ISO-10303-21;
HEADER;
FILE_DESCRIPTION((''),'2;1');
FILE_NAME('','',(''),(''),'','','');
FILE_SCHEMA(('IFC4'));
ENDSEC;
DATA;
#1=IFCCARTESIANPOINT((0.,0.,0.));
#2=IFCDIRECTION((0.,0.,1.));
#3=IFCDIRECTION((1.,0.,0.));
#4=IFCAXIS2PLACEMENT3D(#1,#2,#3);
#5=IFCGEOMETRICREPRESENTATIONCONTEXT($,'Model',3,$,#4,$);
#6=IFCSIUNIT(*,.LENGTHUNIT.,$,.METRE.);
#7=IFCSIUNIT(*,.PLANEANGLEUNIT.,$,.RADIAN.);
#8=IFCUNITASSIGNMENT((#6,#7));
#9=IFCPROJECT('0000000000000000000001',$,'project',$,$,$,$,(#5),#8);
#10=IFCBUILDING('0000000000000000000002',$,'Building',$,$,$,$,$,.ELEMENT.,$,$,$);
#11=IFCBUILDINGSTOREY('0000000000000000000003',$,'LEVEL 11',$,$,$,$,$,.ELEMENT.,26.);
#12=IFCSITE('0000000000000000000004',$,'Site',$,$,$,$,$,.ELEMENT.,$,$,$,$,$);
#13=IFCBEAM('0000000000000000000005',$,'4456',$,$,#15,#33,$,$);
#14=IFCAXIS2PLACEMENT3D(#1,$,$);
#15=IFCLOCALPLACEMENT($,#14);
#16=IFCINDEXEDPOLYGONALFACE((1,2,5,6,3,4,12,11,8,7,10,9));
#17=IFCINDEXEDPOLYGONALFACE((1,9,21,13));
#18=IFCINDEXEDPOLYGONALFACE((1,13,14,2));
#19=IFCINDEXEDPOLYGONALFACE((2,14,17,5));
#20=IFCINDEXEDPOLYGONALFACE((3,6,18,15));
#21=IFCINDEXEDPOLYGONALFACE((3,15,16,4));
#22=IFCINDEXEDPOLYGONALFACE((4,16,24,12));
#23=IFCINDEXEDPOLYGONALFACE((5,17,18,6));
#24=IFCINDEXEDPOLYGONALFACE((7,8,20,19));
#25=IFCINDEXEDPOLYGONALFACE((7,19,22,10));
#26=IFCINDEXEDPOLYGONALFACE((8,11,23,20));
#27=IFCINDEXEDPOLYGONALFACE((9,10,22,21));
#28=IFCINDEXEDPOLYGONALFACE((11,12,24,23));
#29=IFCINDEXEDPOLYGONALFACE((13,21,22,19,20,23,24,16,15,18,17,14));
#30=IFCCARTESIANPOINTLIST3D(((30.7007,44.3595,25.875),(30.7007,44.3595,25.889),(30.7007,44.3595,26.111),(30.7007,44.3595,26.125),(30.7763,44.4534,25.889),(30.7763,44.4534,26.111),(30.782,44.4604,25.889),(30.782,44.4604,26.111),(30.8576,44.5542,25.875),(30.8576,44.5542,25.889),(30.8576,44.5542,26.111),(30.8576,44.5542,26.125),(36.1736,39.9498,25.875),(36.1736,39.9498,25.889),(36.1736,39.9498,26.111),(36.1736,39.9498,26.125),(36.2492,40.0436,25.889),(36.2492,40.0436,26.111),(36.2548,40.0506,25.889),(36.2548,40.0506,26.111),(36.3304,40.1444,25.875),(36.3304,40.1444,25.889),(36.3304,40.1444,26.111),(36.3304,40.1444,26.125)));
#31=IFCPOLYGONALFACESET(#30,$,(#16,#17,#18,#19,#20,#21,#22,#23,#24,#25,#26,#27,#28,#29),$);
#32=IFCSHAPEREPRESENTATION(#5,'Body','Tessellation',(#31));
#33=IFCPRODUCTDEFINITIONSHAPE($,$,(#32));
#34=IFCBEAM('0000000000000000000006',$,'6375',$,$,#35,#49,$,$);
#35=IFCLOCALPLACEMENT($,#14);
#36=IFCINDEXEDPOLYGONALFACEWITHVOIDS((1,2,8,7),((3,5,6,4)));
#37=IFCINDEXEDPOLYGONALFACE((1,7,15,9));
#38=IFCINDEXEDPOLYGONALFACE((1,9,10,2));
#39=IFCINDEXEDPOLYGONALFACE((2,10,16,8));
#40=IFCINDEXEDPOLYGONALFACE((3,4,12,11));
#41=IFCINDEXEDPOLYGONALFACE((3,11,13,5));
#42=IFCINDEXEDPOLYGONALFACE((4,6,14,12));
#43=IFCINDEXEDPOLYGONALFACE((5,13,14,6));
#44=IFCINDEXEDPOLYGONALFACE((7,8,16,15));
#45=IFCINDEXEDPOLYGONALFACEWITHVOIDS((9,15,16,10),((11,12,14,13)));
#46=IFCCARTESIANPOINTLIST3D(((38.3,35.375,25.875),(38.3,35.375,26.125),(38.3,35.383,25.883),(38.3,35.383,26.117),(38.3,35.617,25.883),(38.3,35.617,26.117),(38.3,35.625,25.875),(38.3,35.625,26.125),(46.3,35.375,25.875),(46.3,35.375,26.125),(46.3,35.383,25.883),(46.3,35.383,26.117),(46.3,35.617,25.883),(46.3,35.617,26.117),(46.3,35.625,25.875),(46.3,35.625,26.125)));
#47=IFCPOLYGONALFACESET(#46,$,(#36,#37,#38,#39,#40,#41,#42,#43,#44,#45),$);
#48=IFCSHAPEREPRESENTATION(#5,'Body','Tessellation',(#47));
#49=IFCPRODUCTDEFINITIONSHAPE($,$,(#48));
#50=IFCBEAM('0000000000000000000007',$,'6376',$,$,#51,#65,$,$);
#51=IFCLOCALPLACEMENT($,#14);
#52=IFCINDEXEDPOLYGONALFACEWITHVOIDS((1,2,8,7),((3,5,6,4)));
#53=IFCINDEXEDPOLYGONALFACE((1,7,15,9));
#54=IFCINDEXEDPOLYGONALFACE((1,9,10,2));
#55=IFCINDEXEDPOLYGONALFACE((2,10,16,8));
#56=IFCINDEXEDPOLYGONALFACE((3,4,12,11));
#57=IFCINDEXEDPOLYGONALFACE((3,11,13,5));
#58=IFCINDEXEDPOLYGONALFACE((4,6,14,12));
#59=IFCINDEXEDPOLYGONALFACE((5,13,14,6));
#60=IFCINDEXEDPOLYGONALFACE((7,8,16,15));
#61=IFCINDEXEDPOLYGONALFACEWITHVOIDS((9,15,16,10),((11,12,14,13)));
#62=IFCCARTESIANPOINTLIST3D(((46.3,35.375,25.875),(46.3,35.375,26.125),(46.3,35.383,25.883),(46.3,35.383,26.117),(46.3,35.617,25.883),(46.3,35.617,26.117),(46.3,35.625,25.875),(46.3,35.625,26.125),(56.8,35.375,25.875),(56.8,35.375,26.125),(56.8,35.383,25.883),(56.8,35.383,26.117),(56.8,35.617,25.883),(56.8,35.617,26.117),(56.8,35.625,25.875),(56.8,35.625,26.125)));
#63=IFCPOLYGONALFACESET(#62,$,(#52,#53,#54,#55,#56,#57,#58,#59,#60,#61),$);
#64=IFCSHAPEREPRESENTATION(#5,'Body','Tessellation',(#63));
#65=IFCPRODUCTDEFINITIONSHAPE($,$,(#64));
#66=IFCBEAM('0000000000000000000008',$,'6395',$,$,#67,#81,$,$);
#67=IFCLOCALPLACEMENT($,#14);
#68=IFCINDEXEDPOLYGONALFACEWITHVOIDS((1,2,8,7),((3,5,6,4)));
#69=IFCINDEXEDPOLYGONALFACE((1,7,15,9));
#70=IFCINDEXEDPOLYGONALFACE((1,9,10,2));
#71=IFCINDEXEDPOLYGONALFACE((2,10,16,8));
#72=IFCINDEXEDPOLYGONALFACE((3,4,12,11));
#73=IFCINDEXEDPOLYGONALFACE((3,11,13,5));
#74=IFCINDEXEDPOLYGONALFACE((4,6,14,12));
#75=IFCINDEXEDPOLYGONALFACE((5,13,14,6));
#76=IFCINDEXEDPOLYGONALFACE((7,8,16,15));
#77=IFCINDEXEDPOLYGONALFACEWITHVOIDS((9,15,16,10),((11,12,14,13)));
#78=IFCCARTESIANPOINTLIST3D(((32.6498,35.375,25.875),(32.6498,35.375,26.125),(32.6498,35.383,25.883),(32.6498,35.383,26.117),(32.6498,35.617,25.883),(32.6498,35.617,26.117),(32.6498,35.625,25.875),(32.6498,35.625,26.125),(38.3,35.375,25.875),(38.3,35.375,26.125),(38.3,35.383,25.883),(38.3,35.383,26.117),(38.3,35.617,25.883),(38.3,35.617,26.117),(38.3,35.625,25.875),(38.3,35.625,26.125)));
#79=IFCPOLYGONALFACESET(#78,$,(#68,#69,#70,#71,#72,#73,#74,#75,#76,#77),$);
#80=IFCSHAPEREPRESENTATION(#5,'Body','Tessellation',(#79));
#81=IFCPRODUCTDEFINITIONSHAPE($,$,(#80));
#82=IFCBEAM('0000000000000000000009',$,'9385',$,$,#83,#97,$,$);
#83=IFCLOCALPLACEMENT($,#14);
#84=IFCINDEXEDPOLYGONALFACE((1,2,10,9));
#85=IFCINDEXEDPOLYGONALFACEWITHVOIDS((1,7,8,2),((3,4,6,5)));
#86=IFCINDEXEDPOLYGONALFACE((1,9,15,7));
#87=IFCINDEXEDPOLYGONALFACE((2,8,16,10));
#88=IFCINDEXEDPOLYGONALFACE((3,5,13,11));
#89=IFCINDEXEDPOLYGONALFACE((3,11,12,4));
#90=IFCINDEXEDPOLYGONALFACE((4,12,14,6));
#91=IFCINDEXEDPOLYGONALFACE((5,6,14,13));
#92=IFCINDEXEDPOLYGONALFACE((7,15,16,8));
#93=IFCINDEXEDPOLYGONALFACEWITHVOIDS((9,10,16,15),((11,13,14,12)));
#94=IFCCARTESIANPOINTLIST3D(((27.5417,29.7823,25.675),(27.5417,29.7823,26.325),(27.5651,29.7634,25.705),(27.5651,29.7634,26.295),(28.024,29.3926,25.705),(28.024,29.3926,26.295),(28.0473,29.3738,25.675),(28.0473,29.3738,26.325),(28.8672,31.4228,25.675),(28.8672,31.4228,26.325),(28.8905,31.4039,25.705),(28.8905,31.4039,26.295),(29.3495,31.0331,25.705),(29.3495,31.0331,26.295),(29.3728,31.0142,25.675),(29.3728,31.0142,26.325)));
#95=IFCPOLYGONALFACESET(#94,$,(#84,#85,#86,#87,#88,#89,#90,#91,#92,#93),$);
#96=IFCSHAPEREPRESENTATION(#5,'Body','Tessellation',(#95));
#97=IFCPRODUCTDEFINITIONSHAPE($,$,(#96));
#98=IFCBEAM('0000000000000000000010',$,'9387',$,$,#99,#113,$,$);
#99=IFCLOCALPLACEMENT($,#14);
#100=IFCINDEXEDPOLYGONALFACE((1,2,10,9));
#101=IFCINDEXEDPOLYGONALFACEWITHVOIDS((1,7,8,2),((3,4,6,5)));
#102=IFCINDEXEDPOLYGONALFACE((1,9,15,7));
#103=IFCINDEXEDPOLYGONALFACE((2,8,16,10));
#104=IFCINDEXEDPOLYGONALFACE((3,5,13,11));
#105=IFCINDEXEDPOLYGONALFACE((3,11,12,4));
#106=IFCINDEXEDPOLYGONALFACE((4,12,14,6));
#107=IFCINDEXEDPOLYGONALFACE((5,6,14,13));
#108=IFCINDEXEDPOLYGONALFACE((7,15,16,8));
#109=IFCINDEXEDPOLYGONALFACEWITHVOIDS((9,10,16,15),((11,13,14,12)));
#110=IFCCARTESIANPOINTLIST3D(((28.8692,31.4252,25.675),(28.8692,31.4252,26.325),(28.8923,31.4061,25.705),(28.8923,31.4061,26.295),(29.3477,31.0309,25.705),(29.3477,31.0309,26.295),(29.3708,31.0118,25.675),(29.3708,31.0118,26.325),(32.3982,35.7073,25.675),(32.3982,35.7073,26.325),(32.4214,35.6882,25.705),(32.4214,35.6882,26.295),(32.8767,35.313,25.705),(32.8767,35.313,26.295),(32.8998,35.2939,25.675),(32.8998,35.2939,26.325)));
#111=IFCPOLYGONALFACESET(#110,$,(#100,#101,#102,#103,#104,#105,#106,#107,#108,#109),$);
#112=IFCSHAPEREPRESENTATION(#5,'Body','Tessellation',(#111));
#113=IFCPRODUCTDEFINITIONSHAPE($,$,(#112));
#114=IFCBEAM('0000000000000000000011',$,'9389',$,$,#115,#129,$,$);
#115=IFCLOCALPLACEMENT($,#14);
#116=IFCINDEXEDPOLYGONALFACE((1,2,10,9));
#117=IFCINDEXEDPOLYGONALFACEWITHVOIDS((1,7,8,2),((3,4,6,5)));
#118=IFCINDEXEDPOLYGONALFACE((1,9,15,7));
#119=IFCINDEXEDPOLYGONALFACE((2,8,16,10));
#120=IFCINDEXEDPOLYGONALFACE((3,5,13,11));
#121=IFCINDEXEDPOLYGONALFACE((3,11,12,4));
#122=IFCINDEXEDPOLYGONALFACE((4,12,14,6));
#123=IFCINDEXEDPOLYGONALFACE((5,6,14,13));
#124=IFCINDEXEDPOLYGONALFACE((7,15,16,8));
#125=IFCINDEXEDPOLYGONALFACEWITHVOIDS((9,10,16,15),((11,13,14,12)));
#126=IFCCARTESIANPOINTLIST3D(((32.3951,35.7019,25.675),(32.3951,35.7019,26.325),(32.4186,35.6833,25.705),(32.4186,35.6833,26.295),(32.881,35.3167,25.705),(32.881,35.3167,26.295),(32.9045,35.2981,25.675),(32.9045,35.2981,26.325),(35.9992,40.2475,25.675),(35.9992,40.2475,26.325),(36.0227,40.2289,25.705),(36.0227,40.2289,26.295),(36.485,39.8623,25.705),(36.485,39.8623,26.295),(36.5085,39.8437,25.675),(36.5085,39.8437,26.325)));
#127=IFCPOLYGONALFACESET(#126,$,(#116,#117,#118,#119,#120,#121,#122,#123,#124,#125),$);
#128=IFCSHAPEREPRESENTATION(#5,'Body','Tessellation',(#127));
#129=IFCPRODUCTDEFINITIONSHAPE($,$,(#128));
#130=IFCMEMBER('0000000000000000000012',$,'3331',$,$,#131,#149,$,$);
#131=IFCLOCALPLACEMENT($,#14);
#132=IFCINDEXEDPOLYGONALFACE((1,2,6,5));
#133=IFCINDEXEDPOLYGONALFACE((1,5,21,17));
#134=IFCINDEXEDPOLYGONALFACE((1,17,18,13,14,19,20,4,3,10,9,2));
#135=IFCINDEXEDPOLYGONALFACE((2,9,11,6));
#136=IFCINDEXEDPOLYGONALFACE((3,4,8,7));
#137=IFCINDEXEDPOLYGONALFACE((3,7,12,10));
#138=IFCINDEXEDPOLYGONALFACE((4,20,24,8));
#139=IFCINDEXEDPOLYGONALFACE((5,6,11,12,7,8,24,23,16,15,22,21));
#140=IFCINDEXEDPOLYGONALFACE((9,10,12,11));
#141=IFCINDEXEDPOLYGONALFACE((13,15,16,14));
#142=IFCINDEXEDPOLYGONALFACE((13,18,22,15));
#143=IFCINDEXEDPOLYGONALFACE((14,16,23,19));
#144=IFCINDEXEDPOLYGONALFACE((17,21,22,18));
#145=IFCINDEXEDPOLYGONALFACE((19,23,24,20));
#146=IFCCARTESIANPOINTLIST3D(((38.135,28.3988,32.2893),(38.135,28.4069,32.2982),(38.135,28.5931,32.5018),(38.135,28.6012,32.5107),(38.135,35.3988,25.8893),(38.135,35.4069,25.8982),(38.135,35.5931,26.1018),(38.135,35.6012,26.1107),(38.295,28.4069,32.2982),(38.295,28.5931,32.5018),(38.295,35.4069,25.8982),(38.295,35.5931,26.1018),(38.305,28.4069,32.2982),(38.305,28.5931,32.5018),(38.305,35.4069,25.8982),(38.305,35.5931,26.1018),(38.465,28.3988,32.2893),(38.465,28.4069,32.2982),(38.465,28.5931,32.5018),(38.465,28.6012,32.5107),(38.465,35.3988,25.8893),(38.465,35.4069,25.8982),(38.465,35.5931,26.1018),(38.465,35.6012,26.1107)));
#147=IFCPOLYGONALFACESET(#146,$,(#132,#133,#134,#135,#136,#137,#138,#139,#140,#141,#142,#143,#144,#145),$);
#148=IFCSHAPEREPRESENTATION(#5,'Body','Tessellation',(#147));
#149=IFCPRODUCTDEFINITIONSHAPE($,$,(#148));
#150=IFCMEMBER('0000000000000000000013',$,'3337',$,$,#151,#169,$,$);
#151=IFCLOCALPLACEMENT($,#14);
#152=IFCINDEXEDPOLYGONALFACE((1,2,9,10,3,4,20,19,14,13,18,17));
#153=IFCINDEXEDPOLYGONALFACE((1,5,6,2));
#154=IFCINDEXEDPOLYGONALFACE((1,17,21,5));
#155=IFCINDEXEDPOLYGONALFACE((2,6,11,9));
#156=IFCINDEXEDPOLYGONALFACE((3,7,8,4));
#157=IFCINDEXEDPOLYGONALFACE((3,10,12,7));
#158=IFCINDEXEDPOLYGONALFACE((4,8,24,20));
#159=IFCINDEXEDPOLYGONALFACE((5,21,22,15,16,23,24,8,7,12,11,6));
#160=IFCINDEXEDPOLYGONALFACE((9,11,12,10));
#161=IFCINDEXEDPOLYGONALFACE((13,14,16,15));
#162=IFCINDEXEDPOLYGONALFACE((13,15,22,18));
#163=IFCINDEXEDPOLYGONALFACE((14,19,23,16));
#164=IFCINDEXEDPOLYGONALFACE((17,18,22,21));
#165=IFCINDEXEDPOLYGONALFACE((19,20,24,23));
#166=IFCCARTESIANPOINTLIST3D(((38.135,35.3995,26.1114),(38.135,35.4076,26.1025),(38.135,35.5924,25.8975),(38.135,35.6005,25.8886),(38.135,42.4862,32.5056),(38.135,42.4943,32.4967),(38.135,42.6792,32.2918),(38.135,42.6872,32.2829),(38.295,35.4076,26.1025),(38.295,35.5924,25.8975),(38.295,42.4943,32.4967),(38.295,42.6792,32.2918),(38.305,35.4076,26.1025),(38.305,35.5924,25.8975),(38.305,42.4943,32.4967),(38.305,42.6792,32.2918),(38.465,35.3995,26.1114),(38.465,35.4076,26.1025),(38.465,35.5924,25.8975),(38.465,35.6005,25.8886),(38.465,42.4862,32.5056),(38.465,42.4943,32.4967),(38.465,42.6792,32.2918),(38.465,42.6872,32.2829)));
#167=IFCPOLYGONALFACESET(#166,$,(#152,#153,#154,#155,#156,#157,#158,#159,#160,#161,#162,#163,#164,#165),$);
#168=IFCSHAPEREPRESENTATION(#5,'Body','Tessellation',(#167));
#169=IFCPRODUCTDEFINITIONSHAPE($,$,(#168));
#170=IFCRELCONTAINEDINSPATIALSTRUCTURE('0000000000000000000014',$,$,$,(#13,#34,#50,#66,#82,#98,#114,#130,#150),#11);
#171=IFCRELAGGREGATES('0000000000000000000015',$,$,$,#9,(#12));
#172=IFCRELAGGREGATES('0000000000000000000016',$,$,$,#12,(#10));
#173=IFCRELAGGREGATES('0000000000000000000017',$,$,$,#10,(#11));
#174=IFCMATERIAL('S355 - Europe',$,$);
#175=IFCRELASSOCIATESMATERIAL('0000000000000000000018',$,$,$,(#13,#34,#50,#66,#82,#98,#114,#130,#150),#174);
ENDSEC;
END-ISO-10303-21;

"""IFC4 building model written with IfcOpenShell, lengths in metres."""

from ifc_helpers import new_model, si_unit, frame, origin_with_axes, origin_2d_with_axis, place, context, project, spatial, hollow_rectangle, i_section, extrude, material, material_profile, profile_set, profile_usage, element, save


model = new_model("IFC4")

# Units and contexts
model_context = context("Model", 3, world=origin_with_axes())
ifc_project = project(units=[si_unit("LENGTHUNIT", "METRE"), si_unit("PLANEANGLEUNIT", "RADIAN")], contexts=[model_context])

# Site, building, storey
site = spatial("IfcSite", under=ifc_project, Name="Site", CompositionType="ELEMENT")
building = spatial("IfcBuilding", under=site, Name="Building", CompositionType="ELEMENT")
storey = spatial("IfcBuildingStorey", under=building, Name="LEVEL 11", CompositionType="ELEMENT", Elevation=26.0)

# Shared definitions
ifc_material = material(Name="S355 - Europe")

# Beams
ifc_material_profile_1 = material_profile(ifc_material, i_section(OverallWidth=0.25, OverallDepth=0.25, WebThickness=0.009, FlangeThickness=0.014, at=origin_2d_with_axis()))
ifc_profile_set_1 = profile_set([ifc_material_profile_1])
ifc_profile_usage_1 = profile_usage(ifc_profile_set_1, cardinal=10)
beam_1_placement = place(None, frame((36.252, 40.0471, 26.0), z_axis=(-0.77868, 0.627421, 0.0), x_axis=(-0.627421, -0.77868, 0.0)))
element("IfcBeam", 1, at=beam_1_placement, inside=storey, material=ifc_profile_usage_1, Name="4456", context=model_context, shape_type="SweptSolid", body=[
    extrude(i_section(OverallWidth=0.25, OverallDepth=0.25, WebThickness=0.009, FlangeThickness=0.014, at=origin_2d_with_axis()), origin_with_axes(), (0.0, 0.0, 1.0), 7.0284),
])
ifc_material_profile_2 = material_profile(ifc_material, hollow_rectangle(XDim=0.25, YDim=0.25, WallThickness=0.008, at=origin_2d_with_axis()))
ifc_profile_set_2 = profile_set([ifc_material_profile_2])
ifc_profile_usage_2 = profile_usage(ifc_profile_set_2, cardinal=10)
beam_2_placement = place(None, frame((38.3, 35.5, 26.0), z_axis=(1.0, 0.0, 0.0), x_axis=(0.0, 1.0, 0.0)))
element("IfcBeam", 2, at=beam_2_placement, inside=storey, material=ifc_profile_usage_2, Name="6375", context=model_context, shape_type="SweptSolid", body=[
    extrude(hollow_rectangle(XDim=0.25, YDim=0.25, WallThickness=0.008, at=origin_2d_with_axis()), origin_with_axes(), (0.0, 0.0, 1.0), 8.0),
])
ifc_material_profile_3 = material_profile(ifc_material, hollow_rectangle(XDim=0.25, YDim=0.25, WallThickness=0.008, at=origin_2d_with_axis()))
ifc_profile_set_3 = profile_set([ifc_material_profile_3])
ifc_profile_usage_3 = profile_usage(ifc_profile_set_3, cardinal=10)
beam_3_placement = place(None, frame((46.3, 35.5, 26.0), z_axis=(1.0, 0.0, 0.0), x_axis=(0.0, 1.0, 0.0)))
element("IfcBeam", 3, at=beam_3_placement, inside=storey, material=ifc_profile_usage_3, Name="6376", context=model_context, shape_type="SweptSolid", body=[
    extrude(hollow_rectangle(XDim=0.25, YDim=0.25, WallThickness=0.008, at=origin_2d_with_axis()), origin_with_axes(), (0.0, 0.0, 1.0), 10.5),
])
ifc_material_profile_4 = material_profile(ifc_material, hollow_rectangle(XDim=0.25, YDim=0.25, WallThickness=0.008, at=origin_2d_with_axis()))
ifc_profile_set_4 = profile_set([ifc_material_profile_4])
ifc_profile_usage_4 = profile_usage(ifc_profile_set_4, cardinal=10)
beam_4_placement = place(None, frame((32.6498, 35.5, 26.0), z_axis=(1.0, 0.0, 0.0), x_axis=(0.0, 1.0, 0.0)))
element("IfcBeam", 4, at=beam_4_placement, inside=storey, material=ifc_profile_usage_4, Name="6395", context=model_context, shape_type="SweptSolid", body=[
    extrude(hollow_rectangle(XDim=0.25, YDim=0.25, WallThickness=0.008, at=origin_2d_with_axis()), origin_with_axes(), (0.0, 0.0, 1.0), 5.6502),
])
ifc_material_profile_5 = material_profile(ifc_material, hollow_rectangle(XDim=0.65, YDim=0.65, WallThickness=0.03, at=origin_2d_with_axis()))
ifc_profile_set_5 = profile_set([ifc_material_profile_5])
ifc_profile_usage_5 = profile_usage(ifc_profile_set_5, cardinal=10)
beam_5_placement = place(None, frame((29.12, 31.2185, 26.0), z_axis=(-0.62848, -0.777826, 0.0), x_axis=(0.777711, -0.628621, 0.0)))
element("IfcBeam", 5, at=beam_5_placement, inside=storey, material=ifc_profile_usage_5, Name="9385", context=model_context, shape_type="SweptSolid", body=[
    extrude(hollow_rectangle(XDim=0.65, YDim=0.65, WallThickness=0.03, at=origin_2d_with_axis()), origin_with_axes(), (0.0, 0.0, 1.0), 2.109),
])
ifc_material_profile_6 = material_profile(ifc_material, hollow_rectangle(XDim=0.65, YDim=0.65, WallThickness=0.03, at=origin_2d_with_axis()))
ifc_profile_set_6 = profile_set([ifc_material_profile_6])
ifc_profile_usage_6 = profile_usage(ifc_profile_set_6, cardinal=10)
beam_6_placement = place(None, frame((29.12, 31.2185, 26.0), z_axis=(0.635983, 0.771703, 0.0), x_axis=(-0.771703, 0.635983, 0.0)))
element("IfcBeam", 6, at=beam_6_placement, inside=storey, material=ifc_profile_usage_6, Name="9387", context=model_context, shape_type="SweptSolid", body=[
    extrude(hollow_rectangle(XDim=0.65, YDim=0.65, WallThickness=0.03, at=origin_2d_with_axis()), origin_with_axes(), (0.0, 0.0, 1.0), 5.5489),
])
ifc_material_profile_7 = material_profile(ifc_material, hollow_rectangle(XDim=0.65, YDim=0.65, WallThickness=0.03, at=origin_2d_with_axis()))
ifc_profile_set_7 = profile_set([ifc_material_profile_7])
ifc_profile_usage_7 = profile_usage(ifc_profile_set_7, cardinal=10)
beam_7_placement = place(None, frame((32.6498, 35.5, 26.0), z_axis=(0.621282, 0.783587, 0.0), x_axis=(-0.784074, 0.620667, 0.0)))
element("IfcBeam", 7, at=beam_7_placement, inside=storey, material=ifc_profile_usage_7, Name="9389", context=model_context, shape_type="SweptSolid", body=[
    extrude(hollow_rectangle(XDim=0.65, YDim=0.65, WallThickness=0.03, at=origin_2d_with_axis()), origin_with_axes(), (0.0, 0.0, 1.0), 5.801),
])

# Members
ifc_material_profile_8 = material_profile(ifc_material, i_section(OverallWidth=0.33, OverallDepth=0.3, WebThickness=0.01, FlangeThickness=0.012, at=origin_2d_with_axis()))
ifc_profile_set_8 = profile_set([ifc_material_profile_8])
ifc_profile_usage_8 = profile_usage(ifc_profile_set_8, cardinal=10)
member_1_placement = place(None, frame((38.3, 28.5, 32.4), z_axis=(0.0, 0.738029, -0.674769), x_axis=(-1.0, 0.0, 0.0)))
element("IfcMember", 8, at=member_1_placement, inside=storey, material=ifc_profile_usage_8, Name="3331", context=model_context, shape_type="SweptSolid", body=[
    extrude(i_section(OverallWidth=0.33, OverallDepth=0.3, WebThickness=0.01, FlangeThickness=0.012, at=origin_2d_with_axis()), origin_with_axes(), (0.0, 0.0, 1.0), 9.4847),
])
ifc_material_profile_9 = material_profile(ifc_material, i_section(OverallWidth=0.33, OverallDepth=0.3, WebThickness=0.01, FlangeThickness=0.012, at=origin_2d_with_axis()))
ifc_profile_set_9 = profile_set([ifc_material_profile_9])
ifc_profile_usage_9 = profile_usage(ifc_profile_set_9, cardinal=10)
member_2_placement = place(None, frame((38.3, 35.5, 26.0), z_axis=(0.0, 0.74245, 0.669902), x_axis=(-1.0, 0.0, 0.0)))
element("IfcMember", 9, at=member_2_placement, inside=storey, material=ifc_profile_usage_9, Name="3337", context=model_context, shape_type="SweptSolid", body=[
    extrude(i_section(OverallWidth=0.33, OverallDepth=0.3, WebThickness=0.01, FlangeThickness=0.012, at=origin_2d_with_axis()), origin_with_axes(), (0.0, 0.0, 1.0), 9.545),
])

save(model, "model.ifc")
